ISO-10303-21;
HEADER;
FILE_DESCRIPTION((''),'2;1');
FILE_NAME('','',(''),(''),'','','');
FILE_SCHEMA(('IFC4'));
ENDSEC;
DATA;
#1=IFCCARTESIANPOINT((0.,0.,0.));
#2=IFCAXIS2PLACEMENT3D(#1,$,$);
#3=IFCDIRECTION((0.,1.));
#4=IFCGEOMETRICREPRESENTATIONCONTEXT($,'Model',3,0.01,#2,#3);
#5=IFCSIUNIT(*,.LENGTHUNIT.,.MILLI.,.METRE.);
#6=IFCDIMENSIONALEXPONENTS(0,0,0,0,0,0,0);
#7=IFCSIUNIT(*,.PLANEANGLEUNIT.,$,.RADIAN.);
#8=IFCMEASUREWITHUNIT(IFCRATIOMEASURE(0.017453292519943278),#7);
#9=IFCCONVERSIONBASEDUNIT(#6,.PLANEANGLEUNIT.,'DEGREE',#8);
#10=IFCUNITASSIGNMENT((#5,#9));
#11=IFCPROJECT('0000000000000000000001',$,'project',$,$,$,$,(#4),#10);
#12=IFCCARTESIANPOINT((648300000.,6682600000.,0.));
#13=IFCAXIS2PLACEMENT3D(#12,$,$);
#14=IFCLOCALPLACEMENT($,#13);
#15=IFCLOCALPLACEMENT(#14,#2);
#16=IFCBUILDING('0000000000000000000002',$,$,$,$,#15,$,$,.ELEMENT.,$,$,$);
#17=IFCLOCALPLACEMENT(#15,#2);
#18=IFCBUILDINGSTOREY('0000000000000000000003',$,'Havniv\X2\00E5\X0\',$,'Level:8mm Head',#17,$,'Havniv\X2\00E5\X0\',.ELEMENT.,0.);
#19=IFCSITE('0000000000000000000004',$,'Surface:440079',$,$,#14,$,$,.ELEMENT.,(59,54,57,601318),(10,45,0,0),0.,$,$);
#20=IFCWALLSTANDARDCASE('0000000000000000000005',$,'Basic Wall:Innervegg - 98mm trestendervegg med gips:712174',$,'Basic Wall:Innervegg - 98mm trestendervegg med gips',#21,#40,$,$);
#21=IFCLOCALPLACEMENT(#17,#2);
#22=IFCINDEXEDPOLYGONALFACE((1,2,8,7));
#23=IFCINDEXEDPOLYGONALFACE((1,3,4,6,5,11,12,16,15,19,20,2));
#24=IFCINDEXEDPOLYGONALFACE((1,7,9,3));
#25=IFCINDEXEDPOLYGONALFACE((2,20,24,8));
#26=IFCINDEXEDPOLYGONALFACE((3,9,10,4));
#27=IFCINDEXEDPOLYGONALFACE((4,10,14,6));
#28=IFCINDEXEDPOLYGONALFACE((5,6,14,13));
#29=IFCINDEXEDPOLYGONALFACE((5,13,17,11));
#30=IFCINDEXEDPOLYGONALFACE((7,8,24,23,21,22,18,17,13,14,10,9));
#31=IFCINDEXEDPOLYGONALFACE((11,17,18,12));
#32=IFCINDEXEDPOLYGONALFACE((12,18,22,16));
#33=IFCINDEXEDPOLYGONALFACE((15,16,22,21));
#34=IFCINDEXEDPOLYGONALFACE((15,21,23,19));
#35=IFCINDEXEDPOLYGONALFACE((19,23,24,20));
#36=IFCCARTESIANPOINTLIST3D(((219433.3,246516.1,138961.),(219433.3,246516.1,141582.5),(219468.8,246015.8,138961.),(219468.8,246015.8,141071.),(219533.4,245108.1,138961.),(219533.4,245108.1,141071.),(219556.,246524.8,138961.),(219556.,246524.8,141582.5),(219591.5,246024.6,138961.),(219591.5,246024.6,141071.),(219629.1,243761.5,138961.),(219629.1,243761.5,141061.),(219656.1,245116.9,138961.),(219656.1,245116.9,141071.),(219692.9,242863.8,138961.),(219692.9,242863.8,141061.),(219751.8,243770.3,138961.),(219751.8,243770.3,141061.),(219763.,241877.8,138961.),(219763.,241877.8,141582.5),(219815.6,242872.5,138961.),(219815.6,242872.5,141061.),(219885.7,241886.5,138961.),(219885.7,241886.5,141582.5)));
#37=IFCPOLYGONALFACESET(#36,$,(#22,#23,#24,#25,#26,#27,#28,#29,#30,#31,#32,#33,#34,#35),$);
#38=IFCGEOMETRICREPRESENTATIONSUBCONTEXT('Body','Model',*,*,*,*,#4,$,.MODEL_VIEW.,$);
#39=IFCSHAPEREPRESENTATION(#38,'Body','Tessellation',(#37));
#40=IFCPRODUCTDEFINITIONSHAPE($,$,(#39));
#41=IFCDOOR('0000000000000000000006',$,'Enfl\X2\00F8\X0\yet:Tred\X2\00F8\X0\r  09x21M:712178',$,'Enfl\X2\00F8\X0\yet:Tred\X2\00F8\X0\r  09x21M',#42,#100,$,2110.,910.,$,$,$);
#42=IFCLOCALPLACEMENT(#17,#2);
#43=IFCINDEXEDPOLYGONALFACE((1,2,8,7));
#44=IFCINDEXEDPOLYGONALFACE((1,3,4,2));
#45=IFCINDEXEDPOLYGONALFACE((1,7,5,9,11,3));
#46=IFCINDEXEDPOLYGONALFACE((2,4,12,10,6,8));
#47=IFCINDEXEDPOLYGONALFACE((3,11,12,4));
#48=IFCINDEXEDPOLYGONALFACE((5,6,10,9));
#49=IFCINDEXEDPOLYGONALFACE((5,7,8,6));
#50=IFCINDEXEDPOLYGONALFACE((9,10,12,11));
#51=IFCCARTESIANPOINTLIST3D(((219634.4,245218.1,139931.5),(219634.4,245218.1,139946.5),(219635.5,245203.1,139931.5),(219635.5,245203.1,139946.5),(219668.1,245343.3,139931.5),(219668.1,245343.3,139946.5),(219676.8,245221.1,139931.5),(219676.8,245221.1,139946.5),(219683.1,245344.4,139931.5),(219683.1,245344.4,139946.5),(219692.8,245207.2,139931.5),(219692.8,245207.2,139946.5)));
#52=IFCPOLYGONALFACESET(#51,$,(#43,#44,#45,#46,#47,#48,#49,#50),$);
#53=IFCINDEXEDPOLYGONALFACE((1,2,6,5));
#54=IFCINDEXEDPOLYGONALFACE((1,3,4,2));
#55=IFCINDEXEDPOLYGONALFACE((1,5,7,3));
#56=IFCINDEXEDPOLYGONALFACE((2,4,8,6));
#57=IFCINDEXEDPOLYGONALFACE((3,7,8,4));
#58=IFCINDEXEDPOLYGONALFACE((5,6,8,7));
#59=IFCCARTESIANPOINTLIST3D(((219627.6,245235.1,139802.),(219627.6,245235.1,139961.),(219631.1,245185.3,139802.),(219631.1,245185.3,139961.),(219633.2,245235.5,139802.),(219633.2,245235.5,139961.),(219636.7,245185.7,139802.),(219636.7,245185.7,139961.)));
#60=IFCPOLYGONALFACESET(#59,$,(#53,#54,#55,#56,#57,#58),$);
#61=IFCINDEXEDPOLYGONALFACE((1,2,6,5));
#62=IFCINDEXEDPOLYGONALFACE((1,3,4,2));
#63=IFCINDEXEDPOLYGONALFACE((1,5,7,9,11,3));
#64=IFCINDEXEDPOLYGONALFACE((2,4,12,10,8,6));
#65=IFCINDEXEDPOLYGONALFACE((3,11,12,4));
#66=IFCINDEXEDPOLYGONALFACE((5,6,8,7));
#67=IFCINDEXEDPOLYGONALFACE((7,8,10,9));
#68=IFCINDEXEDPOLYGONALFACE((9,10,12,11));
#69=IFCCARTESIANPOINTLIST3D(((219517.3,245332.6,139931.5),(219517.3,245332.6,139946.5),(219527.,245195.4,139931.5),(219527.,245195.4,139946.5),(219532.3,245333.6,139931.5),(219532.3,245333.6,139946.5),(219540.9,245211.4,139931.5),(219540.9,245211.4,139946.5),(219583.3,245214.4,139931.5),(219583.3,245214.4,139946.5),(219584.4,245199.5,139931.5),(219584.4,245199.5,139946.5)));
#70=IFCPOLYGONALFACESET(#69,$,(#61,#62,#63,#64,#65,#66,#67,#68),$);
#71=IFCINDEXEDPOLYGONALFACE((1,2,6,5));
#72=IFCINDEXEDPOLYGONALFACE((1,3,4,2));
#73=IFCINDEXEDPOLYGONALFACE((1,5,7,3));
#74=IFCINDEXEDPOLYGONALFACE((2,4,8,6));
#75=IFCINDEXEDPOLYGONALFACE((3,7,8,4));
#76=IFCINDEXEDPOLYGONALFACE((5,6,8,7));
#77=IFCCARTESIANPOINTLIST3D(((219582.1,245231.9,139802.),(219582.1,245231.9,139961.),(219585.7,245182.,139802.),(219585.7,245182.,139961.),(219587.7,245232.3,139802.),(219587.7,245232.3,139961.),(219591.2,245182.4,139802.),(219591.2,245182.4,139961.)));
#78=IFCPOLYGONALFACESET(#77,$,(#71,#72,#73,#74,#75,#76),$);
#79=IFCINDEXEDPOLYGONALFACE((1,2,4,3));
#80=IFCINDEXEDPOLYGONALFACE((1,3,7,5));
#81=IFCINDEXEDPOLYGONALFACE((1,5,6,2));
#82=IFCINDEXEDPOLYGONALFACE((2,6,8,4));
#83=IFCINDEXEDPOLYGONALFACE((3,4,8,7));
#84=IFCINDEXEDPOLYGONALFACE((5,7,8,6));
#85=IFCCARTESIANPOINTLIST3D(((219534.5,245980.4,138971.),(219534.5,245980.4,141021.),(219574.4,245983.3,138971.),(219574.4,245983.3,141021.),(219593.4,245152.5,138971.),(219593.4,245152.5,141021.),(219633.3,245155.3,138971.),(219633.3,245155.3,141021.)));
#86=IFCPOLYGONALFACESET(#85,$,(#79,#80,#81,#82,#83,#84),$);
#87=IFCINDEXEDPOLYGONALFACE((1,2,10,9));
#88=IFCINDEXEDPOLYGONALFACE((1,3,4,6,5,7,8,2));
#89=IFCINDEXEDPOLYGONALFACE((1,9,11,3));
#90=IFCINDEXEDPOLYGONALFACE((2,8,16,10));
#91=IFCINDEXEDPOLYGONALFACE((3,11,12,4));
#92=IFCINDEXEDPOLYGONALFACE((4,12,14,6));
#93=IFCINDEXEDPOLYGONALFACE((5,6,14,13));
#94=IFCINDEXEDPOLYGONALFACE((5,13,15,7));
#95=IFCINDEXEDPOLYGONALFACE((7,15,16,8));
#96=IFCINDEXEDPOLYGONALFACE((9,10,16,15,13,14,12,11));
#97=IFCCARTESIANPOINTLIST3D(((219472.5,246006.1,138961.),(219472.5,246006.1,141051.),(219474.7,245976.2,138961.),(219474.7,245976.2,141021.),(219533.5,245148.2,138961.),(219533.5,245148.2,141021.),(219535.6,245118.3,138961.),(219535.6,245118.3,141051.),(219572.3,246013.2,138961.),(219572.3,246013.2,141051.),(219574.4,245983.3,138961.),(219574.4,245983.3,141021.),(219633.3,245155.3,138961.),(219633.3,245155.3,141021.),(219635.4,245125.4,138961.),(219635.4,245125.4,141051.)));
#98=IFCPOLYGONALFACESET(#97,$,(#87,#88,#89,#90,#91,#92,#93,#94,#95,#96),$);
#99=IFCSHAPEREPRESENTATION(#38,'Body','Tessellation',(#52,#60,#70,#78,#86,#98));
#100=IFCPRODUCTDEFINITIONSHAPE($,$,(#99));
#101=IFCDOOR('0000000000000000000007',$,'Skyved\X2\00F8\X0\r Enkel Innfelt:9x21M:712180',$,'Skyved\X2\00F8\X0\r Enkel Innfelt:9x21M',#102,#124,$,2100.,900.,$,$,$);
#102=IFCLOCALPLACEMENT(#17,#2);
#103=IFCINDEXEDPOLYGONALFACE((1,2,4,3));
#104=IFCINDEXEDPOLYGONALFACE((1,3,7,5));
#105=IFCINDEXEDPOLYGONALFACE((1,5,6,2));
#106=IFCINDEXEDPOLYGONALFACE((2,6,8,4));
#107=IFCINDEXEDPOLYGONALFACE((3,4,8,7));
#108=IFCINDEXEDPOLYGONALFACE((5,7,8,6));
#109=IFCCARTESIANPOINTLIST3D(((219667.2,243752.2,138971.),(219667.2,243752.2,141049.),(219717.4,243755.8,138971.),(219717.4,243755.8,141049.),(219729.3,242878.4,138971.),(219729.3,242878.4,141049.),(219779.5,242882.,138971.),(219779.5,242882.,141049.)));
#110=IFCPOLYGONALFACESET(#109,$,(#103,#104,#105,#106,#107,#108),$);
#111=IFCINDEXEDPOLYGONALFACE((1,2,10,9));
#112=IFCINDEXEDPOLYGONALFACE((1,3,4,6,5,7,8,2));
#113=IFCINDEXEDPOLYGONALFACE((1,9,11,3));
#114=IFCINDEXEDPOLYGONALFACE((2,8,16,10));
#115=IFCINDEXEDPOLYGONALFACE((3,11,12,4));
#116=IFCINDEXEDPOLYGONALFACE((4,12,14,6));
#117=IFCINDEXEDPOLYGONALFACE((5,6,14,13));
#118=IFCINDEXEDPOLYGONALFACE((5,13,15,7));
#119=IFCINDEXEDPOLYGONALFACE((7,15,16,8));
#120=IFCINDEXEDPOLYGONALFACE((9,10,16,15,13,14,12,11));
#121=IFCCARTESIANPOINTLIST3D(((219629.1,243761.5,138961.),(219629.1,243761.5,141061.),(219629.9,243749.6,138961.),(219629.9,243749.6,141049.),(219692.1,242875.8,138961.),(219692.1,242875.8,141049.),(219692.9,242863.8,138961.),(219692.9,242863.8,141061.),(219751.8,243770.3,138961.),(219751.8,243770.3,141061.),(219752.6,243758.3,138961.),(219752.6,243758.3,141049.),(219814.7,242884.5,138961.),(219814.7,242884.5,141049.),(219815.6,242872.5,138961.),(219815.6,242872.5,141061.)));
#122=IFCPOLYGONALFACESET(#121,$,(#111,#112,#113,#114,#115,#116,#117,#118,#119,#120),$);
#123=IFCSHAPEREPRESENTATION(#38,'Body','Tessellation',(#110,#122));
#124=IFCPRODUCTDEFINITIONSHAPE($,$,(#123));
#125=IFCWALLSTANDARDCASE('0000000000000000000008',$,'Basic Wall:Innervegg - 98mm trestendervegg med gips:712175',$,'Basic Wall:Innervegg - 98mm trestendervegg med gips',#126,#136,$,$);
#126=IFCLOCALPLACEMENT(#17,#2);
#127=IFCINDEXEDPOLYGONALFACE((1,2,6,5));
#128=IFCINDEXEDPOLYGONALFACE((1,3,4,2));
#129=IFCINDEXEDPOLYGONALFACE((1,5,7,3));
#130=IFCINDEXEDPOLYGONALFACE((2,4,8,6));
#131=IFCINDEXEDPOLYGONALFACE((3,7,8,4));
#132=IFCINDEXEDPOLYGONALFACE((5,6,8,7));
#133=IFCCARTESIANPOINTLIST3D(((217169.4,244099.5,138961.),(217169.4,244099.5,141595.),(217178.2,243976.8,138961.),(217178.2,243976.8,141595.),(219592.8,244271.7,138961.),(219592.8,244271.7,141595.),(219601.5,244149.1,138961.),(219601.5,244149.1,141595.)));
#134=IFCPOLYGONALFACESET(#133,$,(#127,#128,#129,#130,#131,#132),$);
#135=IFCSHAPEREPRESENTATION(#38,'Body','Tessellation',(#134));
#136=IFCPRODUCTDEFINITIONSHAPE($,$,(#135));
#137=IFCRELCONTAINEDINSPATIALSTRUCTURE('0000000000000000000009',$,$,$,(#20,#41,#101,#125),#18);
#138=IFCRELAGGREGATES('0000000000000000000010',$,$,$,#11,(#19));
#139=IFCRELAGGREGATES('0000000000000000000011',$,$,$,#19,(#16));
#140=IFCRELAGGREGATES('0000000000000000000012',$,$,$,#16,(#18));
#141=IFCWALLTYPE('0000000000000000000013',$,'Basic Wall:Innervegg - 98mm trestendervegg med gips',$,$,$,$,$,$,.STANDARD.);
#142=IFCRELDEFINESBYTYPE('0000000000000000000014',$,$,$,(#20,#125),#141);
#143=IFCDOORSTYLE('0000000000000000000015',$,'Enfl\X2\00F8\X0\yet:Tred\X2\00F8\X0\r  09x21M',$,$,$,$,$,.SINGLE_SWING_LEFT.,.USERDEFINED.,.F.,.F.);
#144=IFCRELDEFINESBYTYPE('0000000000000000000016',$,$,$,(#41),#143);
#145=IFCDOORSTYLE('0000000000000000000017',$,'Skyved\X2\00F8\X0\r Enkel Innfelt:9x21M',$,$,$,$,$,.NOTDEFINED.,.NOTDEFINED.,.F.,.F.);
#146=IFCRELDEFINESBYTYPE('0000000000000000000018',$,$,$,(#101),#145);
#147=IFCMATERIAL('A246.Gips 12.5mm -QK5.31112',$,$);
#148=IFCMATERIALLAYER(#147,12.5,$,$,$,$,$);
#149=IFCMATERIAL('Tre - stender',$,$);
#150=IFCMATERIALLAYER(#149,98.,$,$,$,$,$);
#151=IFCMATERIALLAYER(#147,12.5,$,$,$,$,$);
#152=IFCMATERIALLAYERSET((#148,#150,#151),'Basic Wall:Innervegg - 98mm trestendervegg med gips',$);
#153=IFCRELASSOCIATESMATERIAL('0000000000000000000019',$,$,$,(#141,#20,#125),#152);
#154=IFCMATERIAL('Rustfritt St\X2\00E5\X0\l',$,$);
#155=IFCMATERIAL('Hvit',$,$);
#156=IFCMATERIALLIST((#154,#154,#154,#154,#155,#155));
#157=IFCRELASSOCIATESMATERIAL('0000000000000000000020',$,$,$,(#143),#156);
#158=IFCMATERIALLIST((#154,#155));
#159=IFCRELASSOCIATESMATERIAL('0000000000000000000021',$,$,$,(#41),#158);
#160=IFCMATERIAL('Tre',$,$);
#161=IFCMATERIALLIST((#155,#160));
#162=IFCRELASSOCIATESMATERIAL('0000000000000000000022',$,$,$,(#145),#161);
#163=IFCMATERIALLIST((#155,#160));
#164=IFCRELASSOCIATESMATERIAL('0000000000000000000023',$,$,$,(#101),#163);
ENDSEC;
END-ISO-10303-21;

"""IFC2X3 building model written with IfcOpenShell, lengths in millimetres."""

from ifc_helpers import new_model, entity, si_unit, converted_unit, direction, frame, frame_2d, origin, origin_2d_with_axis, place, context, subcontext, project, spatial, polyline, rectangle, outline, extrude, source, transform, mapped, material, material_list, layer, layer_set, layer_usage, type_object, type_shapes, element, fill, save


model = new_model("IFC2X3")

# Units and contexts
model_context = context("Model", 3, precision=0.01, world=origin(), true_north=direction((0.0, 1.0)))
body_context = subcontext(model_context, "Body", "Model", "MODEL_VIEW")
ifc_project = project(units=[si_unit("LENGTHUNIT", "METRE", prefix="MILLI"), converted_unit("PLANEANGLEUNIT", "DEGREE", entity("IfcRatioMeasure", 0.017453292519943278), si_unit("PLANEANGLEUNIT", "RADIAN"), dimensions=[0, 0, 0, 0, 0, 0, 0])], contexts=[model_context])

# Site, building, storey
site_placement = place(None, frame((648300000.0, 6682600000.0, 0.0)))
site = spatial("IfcSite", under=ifc_project, at=site_placement, Name="Surface:440079", CompositionType="ELEMENT", RefLatitude=(59, 54, 57, 601318), RefLongitude=(10, 45, 0, 0), RefElevation=0.0)
building_placement = place(site_placement, origin())
building = spatial("IfcBuilding", under=site, at=building_placement, CompositionType="ELEMENT")
storey_placement = place(building_placement, origin())
storey = spatial("IfcBuildingStorey", under=building, at=storey_placement, Name="Havnivå", ObjectType="Level:8mm Head", LongName="Havnivå", CompositionType="ELEMENT", Elevation=0.0)

# Shared definitions
ifc_material_1 = material(Name="A246.Gips 12.5mm -QK5.31112")
ifc_layer_1 = layer(ifc_material_1, 12.5)
ifc_material_2 = material(Name="Tre - stender")
ifc_layer_2 = layer(ifc_material_2, 98.0)
ifc_layer_3 = layer(ifc_material_1, 12.5)
ifc_layer_set_1 = layer_set([ifc_layer_1, ifc_layer_2, ifc_layer_3], Name="Basic Wall:Innervegg - 98mm trestendervegg med gips")
wall_type_1 = type_object("IfcWallType", Name="Basic Wall:Innervegg - 98mm trestendervegg med gips", PredefinedType="STANDARD", material=ifc_layer_set_1)

# Wall, openings, doors
ifc_material_3 = material(Name="Rustfritt Stål")
ifc_material_4 = material(Name="Hvit")
ifc_material_list_1 = material_list([ifc_material_3, ifc_material_3, ifc_material_3, ifc_material_3, ifc_material_4, ifc_material_4])
door_style_1 = type_object("IfcDoorStyle", Name="Enfløyet:Tredør  09x21M", ConstructionType="USERDEFINED", OperationType="SINGLE_SWING_LEFT", ParameterTakesPrecedence=False, Sizeable=False, material=ifc_material_list_1)
shared_shape_1 = source(origin(), body_context, "Body", "SweptSolid", [
    extrude(outline(polyline([(-33.3, -50.8), (24.2, -50.8), (24.2, 86.7), (9.2, 86.7), (9.2, -35.8), (-33.3, -35.8), (-33.3, -50.8)])), frame((771.7, 121.9, 970.5), z_axis=(0.0, 0.0, 1.0), x_axis=(0.0, 1.0, 0.0)), (0.0, 0.0, 1.0), 15.0),
    extrude(rectangle(XDim=5.6, YDim=50.0, at=frame_2d((0.0, 0.0), x_axis=(1.0, 0.0))), frame((815.0, 85.8, 841.0), z_axis=(0.0, 0.0, 1.0), x_axis=(0.0, -1.0, 0.0)), (0.0, 0.0, 1.0), 159.0),
    extrude(outline(polyline([(-50.8, -33.3), (-35.8, -33.3), (-35.8, 9.2), (86.7, 9.2), (86.7, 24.2), (-50.8, 24.2), (-50.8, -33.3)])), frame((771.7, 4.1, 970.5), z_axis=(0.0, 0.0, 1.0), x_axis=(-1.0, 0.0, 0.0)), (0.0, 0.0, 1.0), 15.0),
    extrude(rectangle(XDim=50.0, YDim=5.6, at=frame_2d((0.0, 0.0), x_axis=(1.0, 0.0))), frame((815.0, 40.2, 841.0)), (0.0, 0.0, 1.0), 159.0),
    extrude(rectangle(XDim=830.0, YDim=40.0, at=origin_2d_with_axis()), frame((455.0, 63.0, 10.0), z_axis=(0.0, 0.0, 1.0), x_axis=(-1.0, 0.0, 0.0)), (0.0, 0.0, 1.0), 2050.0),
    extrude(outline(polyline([(415.0, -1037.5), (445.0, -1037.5), (445.0, 1052.5), (-445.0, 1052.5), (-445.0, -1037.5), (-415.0, -1037.5), (-415.0, 1022.5), (415.0, 1022.5), (415.0, -1037.5)])), frame((455.0, 83.0, 1037.5), z_axis=(0.0, -1.0, 0.0), x_axis=(1.0, 0.0, 0.0)), (0.0, 0.0, 1.0), 100.0),
])
type_shapes(door_style_1, [shared_shape_1])
ifc_layer_usage_1 = layer_usage(ifc_layer_set_1, "AXIS2", "POSITIVE", -61.5)
wall_1_placement = place(storey_placement, frame((219824.3, 241882.2, 138961.0), z_axis=(0.0, 0.0, 1.0), x_axis=(-0.070908, 0.997483, 0.0)))
wall_1 = element("IfcWallStandardCase", 1, at=wall_1_placement, inside=storey, type_object=wall_type_1, material=ifc_layer_usage_1, Name="Basic Wall:Innervegg - 98mm trestendervegg med gips:712174", ObjectType="Basic Wall:Innervegg - 98mm trestendervegg med gips", context=body_context, shape_type="SweptSolid", body=[
    extrude(rectangle(XDim=4650.0, YDim=123.0, at=frame_2d((2325.0, 0.0), x_axis=(1.0, 0.0))), origin(), (0.0, 0.0, 1.0), 2621.5),
])
opening_1_placement = place(wall_1_placement, frame((4148.5, 61.5, 0.0)))
opening_1 = element("IfcOpeningElement", 2, at=opening_1_placement, cuts=wall_1, ObjectType="Opening", context=body_context, shape_type="SweptSolid", body=[
    extrude(rectangle(XDim=2110.0, YDim=910.0, at=frame_2d((1055.0, 455.0), x_axis=(1.0, 0.0))), frame((0.0, 0.0, 0.0), z_axis=(0.0, -1.0, 0.0), x_axis=(0.0, 0.0, 1.0)), (0.0, 0.0, 1.0), 123.0),
])
opening_2_placement = place(wall_1_placement, frame((1888.5, 61.5, 0.0)))
opening_2 = element("IfcOpeningElement", 3, at=opening_2_placement, cuts=wall_1, ObjectType="Opening", context=body_context, shape_type="SweptSolid", body=[
    extrude(rectangle(XDim=2100.0, YDim=900.0, at=frame_2d((1050.0, 450.0), x_axis=(1.0, 0.0))), frame((0.0, 0.0, 0.0), z_axis=(0.0, -1.0, 0.0), x_axis=(0.0, 0.0, 1.0)), (0.0, 0.0, 1.0), 123.0),
])
ifc_material_list_2 = material_list([ifc_material_3, ifc_material_4])
door_1_placement = place(opening_1_placement, frame((0.0, -20.0, 0.0), z_axis=(0.0, 0.0, 1.0), x_axis=(-1.0, 0.0, 0.0)))
door_1 = element("IfcDoor", 4, at=door_1_placement, inside=storey, type_object=door_style_1, material=ifc_material_list_2, Name="Enfløyet:Tredør  09x21M:712178", ObjectType="Enfløyet:Tredør  09x21M", OverallHeight=2110.0, OverallWidth=910.0, context=body_context, shape_type="MappedRepresentation", body=[
    mapped(shared_shape_1, transform((0.0, 0.0, 0.0), scale=1.0)),
])
fill(opening_1, door_1)
ifc_material_5 = material(Name="Tre")
ifc_material_list_3 = material_list([ifc_material_4, ifc_material_5])
ifc_material_list_4 = material_list([ifc_material_4, ifc_material_5])
door_style_2 = type_object("IfcDoorStyle", Name="Skyvedør Enkel Innfelt:9x21M", ConstructionType="NOTDEFINED", OperationType="NOTDEFINED", ParameterTakesPrecedence=False, Sizeable=False, material=ifc_material_list_4)
shared_shape_2 = source(origin(), body_context, "Body", "SweptSolid", [
    extrude(rectangle(XDim=876.0, YDim=50.4, at=frame_2d((0.0, 0.0), x_axis=(1.0, 0.0))), frame((450.0, 62.5, 10.0), z_axis=(0.0, 0.0, 1.0), x_axis=(-1.0, 0.0, 0.0)), (0.0, 0.0, 1.0), 2078.0),
    extrude(outline(polyline([(-1047.0, -438.0), (-1047.0, -450.0), (1053.0, -450.0), (1053.0, 450.0), (-1047.0, 450.0), (-1047.0, 438.0), (1041.0, 438.0), (1041.0, -438.0), (-1047.0, -438.0)])), frame((450.0, 0.0, 1047.0), z_axis=(0.0, -1.0, 0.0), x_axis=(0.0, 0.0, 1.0)), (0.0, 0.0, -1.0), 123.0),
])
type_shapes(door_style_2, [shared_shape_2])
door_2_placement = place(opening_2_placement, frame((0.0, 0.0, 0.0), z_axis=(0.0, 0.0, 1.0), x_axis=(-1.0, 0.0, 0.0)))
door_2 = element("IfcDoor", 5, at=door_2_placement, inside=storey, type_object=door_style_2, material=ifc_material_list_3, Name="Skyvedør Enkel Innfelt:9x21M:712180", ObjectType="Skyvedør Enkel Innfelt:9x21M", OverallHeight=2100.0, OverallWidth=900.0, context=body_context, shape_type="MappedRepresentation", body=[
    mapped(shared_shape_2, transform((0.0, 0.0, 0.0), scale=1.0)),
])
fill(opening_2, door_2)

# Wall
ifc_layer_usage_2 = layer_usage(ifc_layer_set_1, "AXIS2", "NEGATIVE", 61.5)
wall_2_placement = place(storey_placement, frame((219597.2, 244210.4, 138961.0), z_axis=(0.0, 0.0, 1.0), x_axis=(-0.997483, -0.070908, 0.0)))
element("IfcWallStandardCase", 6, at=wall_2_placement, inside=storey, type_object=wall_type_1, material=ifc_layer_usage_2, Name="Basic Wall:Innervegg - 98mm trestendervegg med gips:712175", ObjectType="Basic Wall:Innervegg - 98mm trestendervegg med gips", context=body_context, shape_type="SweptSolid", body=[
    extrude(rectangle(XDim=2429.5, YDim=123.0, at=frame_2d((1214.8, 0.0), x_axis=(-1.0, 0.0))), origin(), (0.0, 0.0, 1.0), 2634.0),
])

save(model, "model.ifc")
